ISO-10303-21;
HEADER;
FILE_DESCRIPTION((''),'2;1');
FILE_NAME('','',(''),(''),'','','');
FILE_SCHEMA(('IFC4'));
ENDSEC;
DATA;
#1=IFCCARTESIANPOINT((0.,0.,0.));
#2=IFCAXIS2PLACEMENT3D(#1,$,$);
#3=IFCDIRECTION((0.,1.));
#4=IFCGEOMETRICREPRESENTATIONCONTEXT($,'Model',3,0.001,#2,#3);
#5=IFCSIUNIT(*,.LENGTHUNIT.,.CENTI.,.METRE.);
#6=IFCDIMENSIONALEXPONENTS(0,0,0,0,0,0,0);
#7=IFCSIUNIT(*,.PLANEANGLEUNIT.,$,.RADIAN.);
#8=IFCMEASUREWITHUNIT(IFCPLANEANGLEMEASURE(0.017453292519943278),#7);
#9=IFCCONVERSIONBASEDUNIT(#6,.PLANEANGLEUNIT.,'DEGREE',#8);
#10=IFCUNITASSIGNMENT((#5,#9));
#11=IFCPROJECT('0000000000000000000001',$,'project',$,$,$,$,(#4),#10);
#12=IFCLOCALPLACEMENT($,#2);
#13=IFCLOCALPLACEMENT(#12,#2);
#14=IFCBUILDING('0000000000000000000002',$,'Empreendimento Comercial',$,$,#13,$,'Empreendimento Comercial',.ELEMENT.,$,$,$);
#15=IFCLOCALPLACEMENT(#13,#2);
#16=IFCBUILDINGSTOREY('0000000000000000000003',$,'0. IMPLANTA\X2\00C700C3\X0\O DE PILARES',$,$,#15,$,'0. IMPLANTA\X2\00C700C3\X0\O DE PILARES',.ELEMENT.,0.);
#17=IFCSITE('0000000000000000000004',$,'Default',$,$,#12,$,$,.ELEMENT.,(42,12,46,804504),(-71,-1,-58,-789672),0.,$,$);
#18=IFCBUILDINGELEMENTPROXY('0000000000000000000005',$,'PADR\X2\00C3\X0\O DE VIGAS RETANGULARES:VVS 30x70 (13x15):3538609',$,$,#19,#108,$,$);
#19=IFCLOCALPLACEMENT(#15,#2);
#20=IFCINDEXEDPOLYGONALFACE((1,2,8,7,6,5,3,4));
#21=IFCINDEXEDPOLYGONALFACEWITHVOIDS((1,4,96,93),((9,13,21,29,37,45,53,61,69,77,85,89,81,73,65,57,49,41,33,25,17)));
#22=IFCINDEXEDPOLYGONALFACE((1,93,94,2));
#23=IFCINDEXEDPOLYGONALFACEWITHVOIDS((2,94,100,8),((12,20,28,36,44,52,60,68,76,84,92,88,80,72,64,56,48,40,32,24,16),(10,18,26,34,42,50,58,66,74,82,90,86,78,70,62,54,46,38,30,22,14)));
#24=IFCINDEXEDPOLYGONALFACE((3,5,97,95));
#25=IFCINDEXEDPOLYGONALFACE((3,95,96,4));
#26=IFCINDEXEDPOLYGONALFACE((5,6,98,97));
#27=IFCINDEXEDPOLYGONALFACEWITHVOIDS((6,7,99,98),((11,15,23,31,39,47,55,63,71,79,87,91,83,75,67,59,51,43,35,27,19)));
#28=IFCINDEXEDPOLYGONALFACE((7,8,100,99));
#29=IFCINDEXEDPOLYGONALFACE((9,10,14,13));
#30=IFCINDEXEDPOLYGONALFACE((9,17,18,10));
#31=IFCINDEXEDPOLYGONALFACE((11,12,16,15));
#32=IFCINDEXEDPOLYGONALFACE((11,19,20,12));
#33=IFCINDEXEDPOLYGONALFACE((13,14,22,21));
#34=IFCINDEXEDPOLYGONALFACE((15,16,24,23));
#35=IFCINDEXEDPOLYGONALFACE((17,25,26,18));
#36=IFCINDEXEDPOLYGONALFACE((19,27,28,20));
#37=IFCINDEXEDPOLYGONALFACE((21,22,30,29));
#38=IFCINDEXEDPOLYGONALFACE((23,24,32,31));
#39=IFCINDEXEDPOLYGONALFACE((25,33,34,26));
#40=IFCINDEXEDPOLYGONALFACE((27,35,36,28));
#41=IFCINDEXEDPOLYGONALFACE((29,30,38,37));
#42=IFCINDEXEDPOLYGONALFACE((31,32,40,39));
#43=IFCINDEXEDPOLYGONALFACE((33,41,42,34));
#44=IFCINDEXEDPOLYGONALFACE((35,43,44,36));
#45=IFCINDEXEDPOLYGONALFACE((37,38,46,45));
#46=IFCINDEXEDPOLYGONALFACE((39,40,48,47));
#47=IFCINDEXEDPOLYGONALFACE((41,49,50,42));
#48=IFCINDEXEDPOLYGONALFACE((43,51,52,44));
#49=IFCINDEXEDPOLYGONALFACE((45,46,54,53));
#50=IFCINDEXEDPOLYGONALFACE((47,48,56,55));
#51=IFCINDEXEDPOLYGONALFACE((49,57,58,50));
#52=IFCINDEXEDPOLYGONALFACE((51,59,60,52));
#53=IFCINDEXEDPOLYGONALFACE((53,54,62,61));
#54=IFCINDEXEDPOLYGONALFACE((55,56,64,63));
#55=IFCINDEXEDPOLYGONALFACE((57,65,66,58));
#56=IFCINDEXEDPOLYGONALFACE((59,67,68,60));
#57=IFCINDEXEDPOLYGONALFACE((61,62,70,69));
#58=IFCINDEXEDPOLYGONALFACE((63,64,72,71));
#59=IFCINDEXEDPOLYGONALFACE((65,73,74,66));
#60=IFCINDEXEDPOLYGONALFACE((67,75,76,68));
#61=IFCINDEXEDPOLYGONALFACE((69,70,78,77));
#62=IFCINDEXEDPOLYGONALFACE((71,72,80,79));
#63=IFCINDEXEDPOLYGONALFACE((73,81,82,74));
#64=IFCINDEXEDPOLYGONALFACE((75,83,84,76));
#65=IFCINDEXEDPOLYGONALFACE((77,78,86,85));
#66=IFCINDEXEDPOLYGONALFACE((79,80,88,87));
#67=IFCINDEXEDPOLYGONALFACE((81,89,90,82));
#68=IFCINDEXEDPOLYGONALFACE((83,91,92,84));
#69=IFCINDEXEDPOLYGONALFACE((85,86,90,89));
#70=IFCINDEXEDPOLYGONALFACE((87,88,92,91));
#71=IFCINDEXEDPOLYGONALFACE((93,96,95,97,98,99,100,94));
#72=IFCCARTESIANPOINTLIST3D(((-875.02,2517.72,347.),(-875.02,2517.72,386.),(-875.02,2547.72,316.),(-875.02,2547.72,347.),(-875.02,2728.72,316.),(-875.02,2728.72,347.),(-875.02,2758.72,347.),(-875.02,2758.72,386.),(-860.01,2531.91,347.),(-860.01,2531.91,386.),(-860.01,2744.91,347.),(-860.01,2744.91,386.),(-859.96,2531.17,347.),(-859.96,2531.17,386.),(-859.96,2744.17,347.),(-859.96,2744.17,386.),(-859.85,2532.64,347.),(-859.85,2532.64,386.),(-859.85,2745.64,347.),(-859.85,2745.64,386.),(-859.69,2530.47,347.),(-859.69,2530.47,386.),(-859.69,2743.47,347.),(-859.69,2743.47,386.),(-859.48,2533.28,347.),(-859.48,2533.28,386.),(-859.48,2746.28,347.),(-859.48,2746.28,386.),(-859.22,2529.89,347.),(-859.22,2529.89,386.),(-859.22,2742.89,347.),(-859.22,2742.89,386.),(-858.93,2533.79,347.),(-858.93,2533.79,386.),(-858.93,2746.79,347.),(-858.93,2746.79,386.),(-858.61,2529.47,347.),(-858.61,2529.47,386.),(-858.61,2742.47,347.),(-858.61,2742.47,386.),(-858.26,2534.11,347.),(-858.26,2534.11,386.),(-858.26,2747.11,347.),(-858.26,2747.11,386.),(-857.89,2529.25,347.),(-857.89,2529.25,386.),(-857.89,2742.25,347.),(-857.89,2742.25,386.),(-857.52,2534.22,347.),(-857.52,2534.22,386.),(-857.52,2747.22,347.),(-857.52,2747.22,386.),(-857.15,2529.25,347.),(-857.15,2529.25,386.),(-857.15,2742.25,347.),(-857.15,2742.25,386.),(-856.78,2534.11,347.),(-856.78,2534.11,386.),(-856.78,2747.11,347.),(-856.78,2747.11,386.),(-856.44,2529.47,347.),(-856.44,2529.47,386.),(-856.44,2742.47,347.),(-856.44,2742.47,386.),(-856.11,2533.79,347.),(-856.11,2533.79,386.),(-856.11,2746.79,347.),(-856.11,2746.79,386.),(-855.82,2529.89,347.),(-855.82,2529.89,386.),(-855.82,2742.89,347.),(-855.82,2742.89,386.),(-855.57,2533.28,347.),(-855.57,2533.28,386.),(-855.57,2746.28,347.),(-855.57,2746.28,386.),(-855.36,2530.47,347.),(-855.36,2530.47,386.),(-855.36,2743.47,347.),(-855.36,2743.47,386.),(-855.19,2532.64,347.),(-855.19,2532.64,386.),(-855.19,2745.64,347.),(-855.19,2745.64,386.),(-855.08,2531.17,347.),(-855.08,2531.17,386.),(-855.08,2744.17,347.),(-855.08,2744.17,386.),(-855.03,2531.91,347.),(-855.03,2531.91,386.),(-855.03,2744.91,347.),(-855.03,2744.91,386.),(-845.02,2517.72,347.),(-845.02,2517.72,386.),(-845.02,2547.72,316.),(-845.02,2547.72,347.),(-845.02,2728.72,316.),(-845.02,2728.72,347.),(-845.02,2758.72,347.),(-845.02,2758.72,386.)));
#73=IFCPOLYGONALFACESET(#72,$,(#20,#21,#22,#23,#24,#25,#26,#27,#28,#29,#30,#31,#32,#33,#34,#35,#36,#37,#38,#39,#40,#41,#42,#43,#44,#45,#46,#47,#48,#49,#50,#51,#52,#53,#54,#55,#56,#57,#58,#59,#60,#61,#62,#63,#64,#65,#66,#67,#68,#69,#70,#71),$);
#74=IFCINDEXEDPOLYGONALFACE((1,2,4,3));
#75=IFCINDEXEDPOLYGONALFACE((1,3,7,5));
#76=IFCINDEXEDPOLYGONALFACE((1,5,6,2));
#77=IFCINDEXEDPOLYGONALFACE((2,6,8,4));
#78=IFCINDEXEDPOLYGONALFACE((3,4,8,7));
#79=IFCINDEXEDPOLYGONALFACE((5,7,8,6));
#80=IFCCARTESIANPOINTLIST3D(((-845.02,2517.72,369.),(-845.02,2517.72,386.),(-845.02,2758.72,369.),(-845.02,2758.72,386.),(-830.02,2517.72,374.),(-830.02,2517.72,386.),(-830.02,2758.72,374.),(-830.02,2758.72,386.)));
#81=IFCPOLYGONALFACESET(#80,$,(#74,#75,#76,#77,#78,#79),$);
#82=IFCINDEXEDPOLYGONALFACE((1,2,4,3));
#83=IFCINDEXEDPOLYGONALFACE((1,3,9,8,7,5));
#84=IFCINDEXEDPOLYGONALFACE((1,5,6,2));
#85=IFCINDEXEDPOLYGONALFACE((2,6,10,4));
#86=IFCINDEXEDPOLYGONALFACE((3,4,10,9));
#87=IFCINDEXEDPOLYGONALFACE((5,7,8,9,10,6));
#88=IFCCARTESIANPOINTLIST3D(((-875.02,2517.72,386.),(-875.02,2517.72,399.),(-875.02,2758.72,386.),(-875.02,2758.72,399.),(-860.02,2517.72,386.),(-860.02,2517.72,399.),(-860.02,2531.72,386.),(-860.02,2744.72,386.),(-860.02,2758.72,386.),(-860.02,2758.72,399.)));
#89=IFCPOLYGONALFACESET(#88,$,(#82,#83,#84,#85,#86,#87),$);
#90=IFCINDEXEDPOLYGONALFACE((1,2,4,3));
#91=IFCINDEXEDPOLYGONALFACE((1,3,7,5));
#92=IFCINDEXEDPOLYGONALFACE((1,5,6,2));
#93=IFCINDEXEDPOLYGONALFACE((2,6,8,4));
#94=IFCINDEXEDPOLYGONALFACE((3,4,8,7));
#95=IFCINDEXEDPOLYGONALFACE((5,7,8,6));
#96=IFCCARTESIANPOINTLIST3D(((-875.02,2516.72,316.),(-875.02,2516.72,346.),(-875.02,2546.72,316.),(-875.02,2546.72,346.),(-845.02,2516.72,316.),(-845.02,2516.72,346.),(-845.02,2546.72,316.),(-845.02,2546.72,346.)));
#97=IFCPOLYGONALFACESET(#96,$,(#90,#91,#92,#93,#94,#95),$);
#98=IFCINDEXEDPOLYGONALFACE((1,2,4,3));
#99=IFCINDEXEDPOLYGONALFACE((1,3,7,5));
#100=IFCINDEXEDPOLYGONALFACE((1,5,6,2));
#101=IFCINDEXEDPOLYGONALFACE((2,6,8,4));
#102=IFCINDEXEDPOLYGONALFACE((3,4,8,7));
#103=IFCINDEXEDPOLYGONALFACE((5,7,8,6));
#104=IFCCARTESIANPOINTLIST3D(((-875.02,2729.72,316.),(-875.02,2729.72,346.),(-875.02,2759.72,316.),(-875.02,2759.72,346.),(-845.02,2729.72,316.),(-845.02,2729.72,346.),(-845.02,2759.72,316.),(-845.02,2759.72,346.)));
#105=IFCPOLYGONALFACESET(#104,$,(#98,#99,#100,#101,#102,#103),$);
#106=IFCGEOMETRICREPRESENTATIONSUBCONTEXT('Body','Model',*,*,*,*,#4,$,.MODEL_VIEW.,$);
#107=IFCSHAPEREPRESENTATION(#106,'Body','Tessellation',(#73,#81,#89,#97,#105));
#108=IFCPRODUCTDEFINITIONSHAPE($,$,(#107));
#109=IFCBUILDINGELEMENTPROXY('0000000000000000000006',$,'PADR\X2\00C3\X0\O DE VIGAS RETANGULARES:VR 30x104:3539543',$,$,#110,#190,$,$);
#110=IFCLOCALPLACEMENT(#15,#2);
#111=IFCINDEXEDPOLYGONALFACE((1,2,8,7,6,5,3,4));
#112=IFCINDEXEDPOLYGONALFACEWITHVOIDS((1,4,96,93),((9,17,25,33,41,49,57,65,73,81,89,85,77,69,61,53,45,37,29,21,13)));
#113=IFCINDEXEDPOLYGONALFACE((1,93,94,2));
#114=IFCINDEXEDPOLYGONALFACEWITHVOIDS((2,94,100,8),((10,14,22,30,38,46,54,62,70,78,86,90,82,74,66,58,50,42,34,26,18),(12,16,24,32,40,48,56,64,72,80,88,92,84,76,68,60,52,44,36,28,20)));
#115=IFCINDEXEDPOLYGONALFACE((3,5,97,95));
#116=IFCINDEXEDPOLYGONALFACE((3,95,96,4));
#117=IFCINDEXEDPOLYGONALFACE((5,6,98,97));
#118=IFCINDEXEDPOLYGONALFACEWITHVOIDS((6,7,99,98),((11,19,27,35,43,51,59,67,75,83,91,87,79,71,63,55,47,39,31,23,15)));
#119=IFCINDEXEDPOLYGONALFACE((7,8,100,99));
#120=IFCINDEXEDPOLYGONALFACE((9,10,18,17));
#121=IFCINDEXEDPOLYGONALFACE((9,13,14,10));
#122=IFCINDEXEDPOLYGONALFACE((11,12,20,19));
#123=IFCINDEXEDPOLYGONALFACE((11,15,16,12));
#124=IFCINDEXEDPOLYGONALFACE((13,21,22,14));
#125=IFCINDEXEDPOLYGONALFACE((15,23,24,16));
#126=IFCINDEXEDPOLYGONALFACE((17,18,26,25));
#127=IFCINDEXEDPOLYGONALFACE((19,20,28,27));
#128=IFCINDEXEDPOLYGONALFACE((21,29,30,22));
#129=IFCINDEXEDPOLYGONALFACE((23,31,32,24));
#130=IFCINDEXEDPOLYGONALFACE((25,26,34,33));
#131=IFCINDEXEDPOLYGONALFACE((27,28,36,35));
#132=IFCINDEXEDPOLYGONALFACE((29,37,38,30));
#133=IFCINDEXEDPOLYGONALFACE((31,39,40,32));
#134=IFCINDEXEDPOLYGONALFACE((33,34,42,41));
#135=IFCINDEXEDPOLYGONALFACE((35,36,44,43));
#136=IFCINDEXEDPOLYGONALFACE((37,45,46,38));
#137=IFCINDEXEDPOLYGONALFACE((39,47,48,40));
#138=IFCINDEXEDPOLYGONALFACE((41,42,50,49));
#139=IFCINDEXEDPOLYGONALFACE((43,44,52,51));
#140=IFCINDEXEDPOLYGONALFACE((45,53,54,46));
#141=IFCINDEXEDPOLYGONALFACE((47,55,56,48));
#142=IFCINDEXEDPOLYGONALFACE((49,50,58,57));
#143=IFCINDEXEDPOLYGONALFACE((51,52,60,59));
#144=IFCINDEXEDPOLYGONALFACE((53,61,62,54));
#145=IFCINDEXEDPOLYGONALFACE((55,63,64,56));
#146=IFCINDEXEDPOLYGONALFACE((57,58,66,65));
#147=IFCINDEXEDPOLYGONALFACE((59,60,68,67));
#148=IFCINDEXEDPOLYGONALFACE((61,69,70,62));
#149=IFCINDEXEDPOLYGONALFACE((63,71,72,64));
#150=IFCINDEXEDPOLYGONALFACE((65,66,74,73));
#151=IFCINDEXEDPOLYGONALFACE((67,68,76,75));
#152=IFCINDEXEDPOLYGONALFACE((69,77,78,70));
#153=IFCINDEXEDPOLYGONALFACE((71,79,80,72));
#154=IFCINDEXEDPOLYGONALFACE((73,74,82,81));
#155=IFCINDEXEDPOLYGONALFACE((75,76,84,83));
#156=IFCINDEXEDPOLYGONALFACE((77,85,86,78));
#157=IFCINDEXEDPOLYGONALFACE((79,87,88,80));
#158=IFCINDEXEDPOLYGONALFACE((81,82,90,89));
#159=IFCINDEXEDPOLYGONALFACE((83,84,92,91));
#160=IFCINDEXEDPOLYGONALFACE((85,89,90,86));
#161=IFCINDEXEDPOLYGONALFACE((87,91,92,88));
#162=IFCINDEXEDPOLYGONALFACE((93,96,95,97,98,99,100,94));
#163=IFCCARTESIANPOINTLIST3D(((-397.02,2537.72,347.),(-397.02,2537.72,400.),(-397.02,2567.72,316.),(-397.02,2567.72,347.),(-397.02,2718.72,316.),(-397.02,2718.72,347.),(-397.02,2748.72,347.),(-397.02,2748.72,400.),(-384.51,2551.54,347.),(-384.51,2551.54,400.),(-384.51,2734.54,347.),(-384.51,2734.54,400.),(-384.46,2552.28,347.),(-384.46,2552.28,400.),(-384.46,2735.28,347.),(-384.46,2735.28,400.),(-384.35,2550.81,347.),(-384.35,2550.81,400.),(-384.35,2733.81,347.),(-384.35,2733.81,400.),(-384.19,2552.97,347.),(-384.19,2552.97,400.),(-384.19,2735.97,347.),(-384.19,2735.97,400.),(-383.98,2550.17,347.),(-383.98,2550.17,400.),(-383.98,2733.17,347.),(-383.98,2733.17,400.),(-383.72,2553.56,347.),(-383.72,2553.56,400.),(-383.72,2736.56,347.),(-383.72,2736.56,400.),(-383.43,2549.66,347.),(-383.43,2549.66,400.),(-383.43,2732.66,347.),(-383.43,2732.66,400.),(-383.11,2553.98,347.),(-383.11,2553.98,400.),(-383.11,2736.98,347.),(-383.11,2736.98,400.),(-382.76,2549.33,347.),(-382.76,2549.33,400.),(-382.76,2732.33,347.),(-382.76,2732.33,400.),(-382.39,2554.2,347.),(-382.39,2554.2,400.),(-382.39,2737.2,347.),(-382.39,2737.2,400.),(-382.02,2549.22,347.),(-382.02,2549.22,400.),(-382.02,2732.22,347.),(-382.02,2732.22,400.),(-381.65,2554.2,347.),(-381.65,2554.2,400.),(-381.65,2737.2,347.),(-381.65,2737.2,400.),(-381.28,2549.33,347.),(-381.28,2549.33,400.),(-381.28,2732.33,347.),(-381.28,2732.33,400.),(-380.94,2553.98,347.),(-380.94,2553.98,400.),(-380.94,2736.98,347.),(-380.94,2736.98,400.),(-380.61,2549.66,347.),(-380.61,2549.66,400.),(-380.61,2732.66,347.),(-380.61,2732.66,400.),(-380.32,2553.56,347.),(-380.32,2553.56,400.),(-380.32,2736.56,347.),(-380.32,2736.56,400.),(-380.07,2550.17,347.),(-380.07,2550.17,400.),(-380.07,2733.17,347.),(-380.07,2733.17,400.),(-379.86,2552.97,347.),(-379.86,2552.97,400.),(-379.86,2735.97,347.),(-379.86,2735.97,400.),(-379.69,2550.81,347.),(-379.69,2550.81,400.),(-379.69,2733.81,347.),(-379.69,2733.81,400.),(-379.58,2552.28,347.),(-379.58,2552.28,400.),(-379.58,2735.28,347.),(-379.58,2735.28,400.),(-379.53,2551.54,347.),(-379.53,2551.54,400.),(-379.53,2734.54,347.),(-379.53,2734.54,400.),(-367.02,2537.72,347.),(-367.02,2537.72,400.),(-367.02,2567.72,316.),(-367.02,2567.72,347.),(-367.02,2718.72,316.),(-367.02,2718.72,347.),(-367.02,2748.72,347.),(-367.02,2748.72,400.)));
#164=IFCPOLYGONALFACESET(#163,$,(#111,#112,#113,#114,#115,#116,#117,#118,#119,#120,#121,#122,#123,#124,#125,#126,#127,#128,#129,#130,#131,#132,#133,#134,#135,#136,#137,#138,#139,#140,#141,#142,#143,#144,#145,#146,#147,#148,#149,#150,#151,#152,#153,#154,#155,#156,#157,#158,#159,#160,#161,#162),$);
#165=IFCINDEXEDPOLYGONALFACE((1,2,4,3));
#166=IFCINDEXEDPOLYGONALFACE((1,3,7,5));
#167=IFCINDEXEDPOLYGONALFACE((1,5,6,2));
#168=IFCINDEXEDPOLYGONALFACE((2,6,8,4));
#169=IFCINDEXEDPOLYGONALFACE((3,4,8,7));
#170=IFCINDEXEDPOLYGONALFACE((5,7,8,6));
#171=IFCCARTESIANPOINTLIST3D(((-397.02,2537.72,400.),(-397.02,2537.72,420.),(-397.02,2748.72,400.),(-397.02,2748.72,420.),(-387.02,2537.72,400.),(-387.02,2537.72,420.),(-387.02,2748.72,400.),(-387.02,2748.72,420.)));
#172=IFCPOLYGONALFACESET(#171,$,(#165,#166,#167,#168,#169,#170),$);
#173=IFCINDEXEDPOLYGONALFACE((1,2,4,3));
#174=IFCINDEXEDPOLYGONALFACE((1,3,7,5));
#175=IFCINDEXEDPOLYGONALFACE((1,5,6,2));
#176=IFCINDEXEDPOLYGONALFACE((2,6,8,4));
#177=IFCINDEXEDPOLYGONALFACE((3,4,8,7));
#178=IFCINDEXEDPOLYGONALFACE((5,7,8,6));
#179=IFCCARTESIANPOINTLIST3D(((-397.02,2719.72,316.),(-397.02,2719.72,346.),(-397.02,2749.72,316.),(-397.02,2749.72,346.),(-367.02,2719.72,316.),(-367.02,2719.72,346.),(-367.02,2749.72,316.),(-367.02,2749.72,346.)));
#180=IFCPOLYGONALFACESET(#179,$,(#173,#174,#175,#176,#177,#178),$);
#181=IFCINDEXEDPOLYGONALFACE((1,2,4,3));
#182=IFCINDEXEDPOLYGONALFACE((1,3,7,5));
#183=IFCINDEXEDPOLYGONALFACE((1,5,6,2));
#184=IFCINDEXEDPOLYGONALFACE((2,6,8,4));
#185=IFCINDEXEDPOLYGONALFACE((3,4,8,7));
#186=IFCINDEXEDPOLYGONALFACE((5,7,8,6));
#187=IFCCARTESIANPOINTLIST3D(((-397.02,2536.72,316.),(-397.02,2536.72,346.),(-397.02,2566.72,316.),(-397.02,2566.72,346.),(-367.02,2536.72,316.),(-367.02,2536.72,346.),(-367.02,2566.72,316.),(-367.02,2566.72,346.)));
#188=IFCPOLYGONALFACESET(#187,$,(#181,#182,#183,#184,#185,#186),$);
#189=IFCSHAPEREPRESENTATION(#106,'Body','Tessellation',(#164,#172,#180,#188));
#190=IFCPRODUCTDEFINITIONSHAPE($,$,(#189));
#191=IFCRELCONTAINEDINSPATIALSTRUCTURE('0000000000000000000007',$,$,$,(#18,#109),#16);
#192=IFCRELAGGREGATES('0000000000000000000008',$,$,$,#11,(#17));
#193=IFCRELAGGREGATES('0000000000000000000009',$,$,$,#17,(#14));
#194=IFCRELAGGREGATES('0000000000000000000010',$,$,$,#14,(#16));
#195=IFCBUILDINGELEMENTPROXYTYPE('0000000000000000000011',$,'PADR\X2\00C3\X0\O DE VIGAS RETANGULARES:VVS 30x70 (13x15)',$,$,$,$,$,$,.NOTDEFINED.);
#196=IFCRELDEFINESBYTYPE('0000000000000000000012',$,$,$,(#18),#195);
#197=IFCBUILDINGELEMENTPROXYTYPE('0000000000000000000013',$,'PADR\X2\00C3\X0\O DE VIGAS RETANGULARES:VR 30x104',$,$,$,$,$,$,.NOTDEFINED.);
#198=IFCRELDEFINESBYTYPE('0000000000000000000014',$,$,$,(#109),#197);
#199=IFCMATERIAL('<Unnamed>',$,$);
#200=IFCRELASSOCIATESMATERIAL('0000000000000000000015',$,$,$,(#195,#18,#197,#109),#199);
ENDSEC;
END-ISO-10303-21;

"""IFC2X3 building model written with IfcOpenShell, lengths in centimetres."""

from ifc_helpers import new_model, entity, si_unit, converted_unit, direction, frame, frame_2d, origin, origin_2d_with_axis, place, context, subcontext, project, spatial, polyline, rectangle, circle, outline, extrude, source, transform, mapped, material, type_object, type_shapes, element, save


model = new_model("IFC2X3")

# Units and contexts
model_context = context("Model", 3, precision=0.001, world=origin(), true_north=direction((0.0, 1.0)))
body_context = subcontext(model_context, "Body", "Model", "MODEL_VIEW")
ifc_project = project(units=[si_unit("LENGTHUNIT", "METRE", prefix="CENTI"), converted_unit("PLANEANGLEUNIT", "DEGREE", entity("IfcPlaneAngleMeasure", 0.017453292519943278), si_unit("PLANEANGLEUNIT", "RADIAN"), dimensions=[0, 0, 0, 0, 0, 0, 0])], contexts=[model_context])

# Site, building, storey
site_placement = place(None, origin())
site = spatial("IfcSite", under=ifc_project, at=site_placement, Name="Default", CompositionType="ELEMENT", RefLatitude=(42, 12, 46, 804504), RefLongitude=(-71, -1, -58, -789672), RefElevation=0.0)
building_placement = place(site_placement, origin())
building = spatial("IfcBuilding", under=site, at=building_placement, Name="Empreendimento Comercial", LongName="Empreendimento Comercial", CompositionType="ELEMENT")
storey_placement = place(building_placement, origin())
storey = spatial("IfcBuildingStorey", under=building, at=storey_placement, Name="0. IMPLANTAÇÃO DE PILARES", LongName="0. IMPLANTAÇÃO DE PILARES", CompositionType="ELEMENT", Elevation=0.0)

# Shared definitions
ifc_material_1 = material(Name="<Unnamed>")

# Building element proxies, openings
building_element_proxy_type_1 = type_object("IfcBuildingElementProxyType", Name="PADRÃO DE VIGAS RETANGULARES:VVS 30x70 (13x15)", PredefinedType="NOTDEFINED", material=ifc_material_1)
shared_shape_1 = source(origin(), body_context, "Body", "SweptSolid", [
    extrude(outline(polyline([(-37.0, -120.5), (2.0, -120.5), (2.0, -90.5), (33.0, -90.5), (33.0, 90.5), (2.0, 90.5), (2.0, 120.5), (-37.0, 120.5), (-37.0, -120.5)])), frame((-875.02, 2638.22, 349.0), z_axis=(1.0, 0.0, 0.0), x_axis=(0.0, 0.0, -1.0)), (0.0, 0.0, 1.0), 30.0),
    extrude(outline(polyline([(-7.25, -7.5), (4.75, -7.5), (9.75, 7.5), (-7.25, 7.5), (-7.25, -7.5)])), frame((-837.52, 2517.72, 378.75), z_axis=(0.0, 1.0, 0.0), x_axis=(0.0, 0.0, -1.0)), (0.0, 0.0, 1.0), 241.0),
    extrude(rectangle(XDim=241.0, YDim=15.0, at=origin_2d_with_axis()), frame((-867.52, 2638.22, 386.0), z_axis=(0.0, 0.0, 1.0), x_axis=(0.0, -1.0, 0.0)), (0.0, 0.0, 1.0), 13.0),
    extrude(rectangle(XDim=30.0, YDim=30.0, at=frame_2d((0.0, 0.0), x_axis=(1.0, 0.0))), frame((-860.02, 2531.72, 316.0), z_axis=(0.0, 0.0, 1.0), x_axis=(-1.0, 0.0, 0.0)), (0.0, 0.0, 1.0), 30.0),
    extrude(rectangle(XDim=30.0, YDim=30.0, at=frame_2d((0.0, 0.0), x_axis=(1.0, 0.0))), frame((-860.02, 2744.72, 316.0), z_axis=(0.0, 0.0, 1.0), x_axis=(-1.0, 0.0, 0.0)), (0.0, 0.0, 1.0), 30.0),
])
type_shapes(building_element_proxy_type_1, [shared_shape_1])
proxy_1_placement = place(storey_placement, origin())
proxy_1 = element("IfcBuildingElementProxy", 1, at=proxy_1_placement, inside=storey, type_object=building_element_proxy_type_1, material=ifc_material_1, Name="PADRÃO DE VIGAS RETANGULARES:VVS 30x70 (13x15):3538609", context=body_context, shape_type="MappedRepresentation", body=[
    mapped(shared_shape_1, transform((0.0, 0.0, 0.0), scale=1.0)),
])
opening_1_placement = place(storey_placement, origin())
element("IfcOpeningElement", 2, at=opening_1_placement, cuts=proxy_1, ObjectType="Opening", context=body_context, shape_type="SweptSolid", body=[
    extrude(circle(Radius=2.5, at=origin_2d_with_axis()), frame((-857.52, 2744.72, 386.0), z_axis=(0.0, 0.0, -1.0), x_axis=(0.0, 1.0, 0.0)), (0.0, 0.0, 1.0), 39.0),
])
opening_2_placement = place(storey_placement, origin())
element("IfcOpeningElement", 3, at=opening_2_placement, cuts=proxy_1, ObjectType="Opening", context=body_context, shape_type="SweptSolid", body=[
    extrude(circle(Radius=2.5, at=origin_2d_with_axis()), frame((-857.52, 2531.72, 386.0), z_axis=(0.0, 0.0, -1.0), x_axis=(0.0, 1.0, 0.0)), (0.0, 0.0, 1.0), 39.0),
])
building_element_proxy_type_2 = type_object("IfcBuildingElementProxyType", Name="PADRÃO DE VIGAS RETANGULARES:VR 30x104", PredefinedType="NOTDEFINED", material=ifc_material_1)
shared_shape_2 = source(origin(), body_context, "Body", "SweptSolid", [
    extrude(outline(polyline([(-105.5, -47.5), (105.5, -47.5), (105.5, 5.5), (75.5, 5.5), (75.5, 36.5), (-75.5, 36.5), (-75.5, 5.5), (-105.5, 5.5), (-105.5, -47.5)])), frame((-397.02, 2643.22, 352.5), z_axis=(1.0, 0.0, 0.0), x_axis=(0.0, -1.0, 0.0)), (0.0, 0.0, 1.0), 30.0),
    extrude(rectangle(XDim=10.0, YDim=211.0, at=frame_2d((0.0, 0.0), x_axis=(1.0, 0.0))), frame((-392.02, 2643.22, 400.0)), (0.0, 0.0, 1.0), 20.0),
    extrude(rectangle(XDim=30.0, YDim=30.0, at=frame_2d((0.0, 0.0), x_axis=(1.0, 0.0))), frame((-382.02, 2734.72, 316.0), z_axis=(0.0, 0.0, 1.0), x_axis=(0.0, 1.0, 0.0)), (0.0, 0.0, 1.0), 30.0),
    extrude(rectangle(XDim=30.0, YDim=30.0, at=frame_2d((0.0, 0.0), x_axis=(1.0, 0.0))), frame((-382.02, 2551.72, 316.0), z_axis=(0.0, 0.0, 1.0), x_axis=(0.0, 1.0, 0.0)), (0.0, 0.0, 1.0), 30.0),
])
type_shapes(building_element_proxy_type_2, [shared_shape_2])
proxy_2_placement = place(storey_placement, origin())
proxy_2 = element("IfcBuildingElementProxy", 4, at=proxy_2_placement, inside=storey, type_object=building_element_proxy_type_2, material=ifc_material_1, Name="PADRÃO DE VIGAS RETANGULARES:VR 30x104:3539543", context=body_context, shape_type="MappedRepresentation", body=[
    mapped(shared_shape_2, transform((0.0, 0.0, 0.0), scale=1.0)),
])
opening_3_placement = place(storey_placement, origin())
element("IfcOpeningElement", 5, at=opening_3_placement, cuts=proxy_2, ObjectType="Opening", context=body_context, shape_type="SweptSolid", body=[
    extrude(circle(Radius=2.5, at=origin_2d_with_axis()), frame((-382.02, 2551.72, 347.0), z_axis=(0.0, 0.0, 1.0), x_axis=(0.0, -1.0, 0.0)), (0.0, 0.0, 1.0), 53.0),
])
opening_4_placement = place(storey_placement, origin())
element("IfcOpeningElement", 6, at=opening_4_placement, cuts=proxy_2, ObjectType="Opening", context=body_context, shape_type="SweptSolid", body=[
    extrude(circle(Radius=2.5, at=origin_2d_with_axis()), frame((-382.02, 2734.72, 347.0), z_axis=(0.0, 0.0, 1.0), x_axis=(0.0, -1.0, 0.0)), (0.0, 0.0, 1.0), 53.0),
])

save(model, "model.ifc")
